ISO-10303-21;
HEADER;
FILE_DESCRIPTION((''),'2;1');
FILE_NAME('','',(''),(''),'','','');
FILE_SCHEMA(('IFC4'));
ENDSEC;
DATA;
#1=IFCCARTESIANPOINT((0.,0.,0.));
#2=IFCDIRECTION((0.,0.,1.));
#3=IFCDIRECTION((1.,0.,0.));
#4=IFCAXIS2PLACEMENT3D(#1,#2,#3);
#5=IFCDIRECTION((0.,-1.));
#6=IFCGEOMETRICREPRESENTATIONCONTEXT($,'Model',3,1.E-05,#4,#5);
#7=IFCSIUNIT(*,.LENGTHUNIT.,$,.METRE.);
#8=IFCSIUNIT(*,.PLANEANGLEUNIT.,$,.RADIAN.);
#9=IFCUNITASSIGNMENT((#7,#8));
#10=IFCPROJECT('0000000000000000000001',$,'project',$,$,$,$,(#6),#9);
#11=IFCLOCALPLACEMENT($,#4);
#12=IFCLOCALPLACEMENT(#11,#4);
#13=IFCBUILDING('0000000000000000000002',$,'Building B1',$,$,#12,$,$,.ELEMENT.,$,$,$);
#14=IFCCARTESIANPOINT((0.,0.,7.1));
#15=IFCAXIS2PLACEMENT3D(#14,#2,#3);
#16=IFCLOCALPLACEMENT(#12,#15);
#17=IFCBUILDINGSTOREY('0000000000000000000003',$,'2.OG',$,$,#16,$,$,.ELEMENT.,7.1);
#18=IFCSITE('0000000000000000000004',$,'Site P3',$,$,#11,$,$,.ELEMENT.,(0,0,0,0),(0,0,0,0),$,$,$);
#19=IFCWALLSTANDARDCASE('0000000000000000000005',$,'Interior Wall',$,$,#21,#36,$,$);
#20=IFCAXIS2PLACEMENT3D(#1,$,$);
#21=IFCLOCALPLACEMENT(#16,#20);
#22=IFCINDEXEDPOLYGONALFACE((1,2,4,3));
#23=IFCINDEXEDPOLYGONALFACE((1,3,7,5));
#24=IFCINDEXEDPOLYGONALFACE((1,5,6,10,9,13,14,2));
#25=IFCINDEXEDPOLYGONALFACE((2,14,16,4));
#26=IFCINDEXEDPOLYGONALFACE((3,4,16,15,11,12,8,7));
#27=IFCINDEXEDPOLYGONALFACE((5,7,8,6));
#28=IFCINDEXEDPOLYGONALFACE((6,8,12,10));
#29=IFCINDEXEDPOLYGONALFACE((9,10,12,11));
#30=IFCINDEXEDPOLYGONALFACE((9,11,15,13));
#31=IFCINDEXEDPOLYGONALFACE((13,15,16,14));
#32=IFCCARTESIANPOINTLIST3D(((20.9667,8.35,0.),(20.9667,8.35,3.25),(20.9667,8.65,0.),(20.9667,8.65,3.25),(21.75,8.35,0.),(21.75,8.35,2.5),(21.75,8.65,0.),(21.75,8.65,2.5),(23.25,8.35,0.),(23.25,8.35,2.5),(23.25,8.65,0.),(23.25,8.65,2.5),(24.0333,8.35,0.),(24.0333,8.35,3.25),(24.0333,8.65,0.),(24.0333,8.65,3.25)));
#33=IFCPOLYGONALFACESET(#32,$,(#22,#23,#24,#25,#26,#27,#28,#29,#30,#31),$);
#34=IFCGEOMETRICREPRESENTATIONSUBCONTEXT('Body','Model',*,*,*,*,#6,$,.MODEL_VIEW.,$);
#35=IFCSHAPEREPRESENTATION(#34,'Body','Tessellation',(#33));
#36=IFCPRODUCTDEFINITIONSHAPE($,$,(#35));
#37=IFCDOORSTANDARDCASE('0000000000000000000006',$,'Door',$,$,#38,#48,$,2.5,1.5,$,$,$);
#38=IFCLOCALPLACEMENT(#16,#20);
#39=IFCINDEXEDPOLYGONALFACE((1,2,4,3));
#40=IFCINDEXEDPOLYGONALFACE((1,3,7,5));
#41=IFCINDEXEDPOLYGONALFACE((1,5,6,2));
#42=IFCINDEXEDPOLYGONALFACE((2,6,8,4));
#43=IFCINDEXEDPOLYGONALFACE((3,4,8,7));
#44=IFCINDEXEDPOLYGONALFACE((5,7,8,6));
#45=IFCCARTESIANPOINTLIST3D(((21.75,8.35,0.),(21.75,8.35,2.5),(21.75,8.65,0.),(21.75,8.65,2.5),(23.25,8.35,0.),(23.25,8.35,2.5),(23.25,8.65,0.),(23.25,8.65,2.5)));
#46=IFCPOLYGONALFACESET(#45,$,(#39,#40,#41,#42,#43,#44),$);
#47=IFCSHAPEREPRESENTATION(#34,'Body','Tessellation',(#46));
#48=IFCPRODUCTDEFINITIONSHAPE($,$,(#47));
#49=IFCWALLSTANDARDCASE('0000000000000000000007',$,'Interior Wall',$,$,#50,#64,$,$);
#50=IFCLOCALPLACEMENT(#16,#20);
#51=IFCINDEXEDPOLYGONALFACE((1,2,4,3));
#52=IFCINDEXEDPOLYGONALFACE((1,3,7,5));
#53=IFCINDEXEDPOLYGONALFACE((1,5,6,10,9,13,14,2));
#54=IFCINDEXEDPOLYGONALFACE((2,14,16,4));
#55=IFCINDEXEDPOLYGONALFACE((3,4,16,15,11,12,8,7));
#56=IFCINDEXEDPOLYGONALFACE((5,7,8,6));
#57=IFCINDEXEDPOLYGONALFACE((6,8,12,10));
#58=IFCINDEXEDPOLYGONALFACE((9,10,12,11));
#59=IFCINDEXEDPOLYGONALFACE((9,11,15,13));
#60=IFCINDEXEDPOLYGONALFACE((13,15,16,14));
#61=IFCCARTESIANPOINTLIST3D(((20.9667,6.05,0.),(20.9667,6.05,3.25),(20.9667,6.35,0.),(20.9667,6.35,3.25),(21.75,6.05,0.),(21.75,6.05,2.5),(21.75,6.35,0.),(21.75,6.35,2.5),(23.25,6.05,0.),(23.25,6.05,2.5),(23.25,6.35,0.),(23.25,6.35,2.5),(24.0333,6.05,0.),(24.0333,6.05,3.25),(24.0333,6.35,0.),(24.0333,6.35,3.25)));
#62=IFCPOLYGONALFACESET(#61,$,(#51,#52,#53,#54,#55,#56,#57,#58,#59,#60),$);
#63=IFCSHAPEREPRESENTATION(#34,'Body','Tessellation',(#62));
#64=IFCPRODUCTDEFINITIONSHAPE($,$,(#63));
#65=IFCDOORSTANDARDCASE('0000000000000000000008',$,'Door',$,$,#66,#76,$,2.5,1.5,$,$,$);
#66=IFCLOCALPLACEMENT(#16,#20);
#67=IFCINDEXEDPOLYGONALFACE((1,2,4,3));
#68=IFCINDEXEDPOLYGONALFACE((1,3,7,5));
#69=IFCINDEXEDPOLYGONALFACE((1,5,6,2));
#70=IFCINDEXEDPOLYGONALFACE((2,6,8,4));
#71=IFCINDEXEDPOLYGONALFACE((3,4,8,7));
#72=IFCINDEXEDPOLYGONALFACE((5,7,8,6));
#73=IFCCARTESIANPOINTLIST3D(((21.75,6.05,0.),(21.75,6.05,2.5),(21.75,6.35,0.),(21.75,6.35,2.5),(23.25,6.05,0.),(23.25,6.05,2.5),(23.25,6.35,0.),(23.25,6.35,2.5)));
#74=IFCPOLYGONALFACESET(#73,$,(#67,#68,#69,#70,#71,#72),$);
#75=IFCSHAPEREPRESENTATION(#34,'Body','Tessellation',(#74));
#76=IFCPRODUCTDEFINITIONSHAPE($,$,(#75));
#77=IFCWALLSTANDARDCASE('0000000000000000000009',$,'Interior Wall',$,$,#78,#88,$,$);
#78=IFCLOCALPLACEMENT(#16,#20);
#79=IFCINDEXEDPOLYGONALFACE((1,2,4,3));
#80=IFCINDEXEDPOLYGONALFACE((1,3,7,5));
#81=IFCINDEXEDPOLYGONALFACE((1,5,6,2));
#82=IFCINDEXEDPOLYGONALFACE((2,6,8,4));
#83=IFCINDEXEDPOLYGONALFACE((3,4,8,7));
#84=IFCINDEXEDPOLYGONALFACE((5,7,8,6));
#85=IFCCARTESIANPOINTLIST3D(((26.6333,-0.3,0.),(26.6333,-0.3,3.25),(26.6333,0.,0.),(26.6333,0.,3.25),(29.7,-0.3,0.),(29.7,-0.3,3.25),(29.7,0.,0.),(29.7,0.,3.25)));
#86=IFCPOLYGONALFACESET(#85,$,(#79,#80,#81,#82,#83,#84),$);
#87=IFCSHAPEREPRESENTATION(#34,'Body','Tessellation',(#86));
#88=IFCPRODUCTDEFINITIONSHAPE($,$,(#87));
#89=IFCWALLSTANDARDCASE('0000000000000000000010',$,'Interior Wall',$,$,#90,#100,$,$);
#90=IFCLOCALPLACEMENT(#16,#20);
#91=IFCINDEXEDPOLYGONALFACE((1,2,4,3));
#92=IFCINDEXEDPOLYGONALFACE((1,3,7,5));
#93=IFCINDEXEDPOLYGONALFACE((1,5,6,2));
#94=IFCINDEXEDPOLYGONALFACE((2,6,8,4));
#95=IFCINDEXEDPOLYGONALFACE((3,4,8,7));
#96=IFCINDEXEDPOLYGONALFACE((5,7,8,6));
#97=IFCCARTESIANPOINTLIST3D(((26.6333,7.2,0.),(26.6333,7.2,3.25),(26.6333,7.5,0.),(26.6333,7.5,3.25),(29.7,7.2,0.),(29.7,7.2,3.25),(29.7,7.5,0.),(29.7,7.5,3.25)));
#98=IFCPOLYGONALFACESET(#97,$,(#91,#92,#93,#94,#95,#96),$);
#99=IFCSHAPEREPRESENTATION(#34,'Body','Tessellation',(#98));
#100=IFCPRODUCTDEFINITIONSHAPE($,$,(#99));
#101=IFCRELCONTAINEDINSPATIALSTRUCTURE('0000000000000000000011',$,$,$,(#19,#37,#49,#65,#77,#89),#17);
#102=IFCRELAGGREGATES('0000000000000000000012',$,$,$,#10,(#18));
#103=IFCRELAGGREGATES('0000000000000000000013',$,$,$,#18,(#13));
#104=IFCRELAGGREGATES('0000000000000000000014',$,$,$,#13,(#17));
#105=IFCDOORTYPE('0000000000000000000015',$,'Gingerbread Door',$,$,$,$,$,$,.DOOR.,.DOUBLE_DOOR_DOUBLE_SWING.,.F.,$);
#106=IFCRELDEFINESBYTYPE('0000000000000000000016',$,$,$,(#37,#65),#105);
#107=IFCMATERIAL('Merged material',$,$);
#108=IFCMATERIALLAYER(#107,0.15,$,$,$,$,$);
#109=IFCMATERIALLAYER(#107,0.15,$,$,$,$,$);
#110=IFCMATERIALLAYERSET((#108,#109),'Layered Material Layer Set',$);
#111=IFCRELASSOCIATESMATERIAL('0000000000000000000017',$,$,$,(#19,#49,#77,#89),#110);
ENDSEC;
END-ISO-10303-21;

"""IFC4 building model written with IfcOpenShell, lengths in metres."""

from ifc_helpers import new_model, si_unit, direction, frame, origin_with_axes, place, context, subcontext, project, spatial, polyline, outline, extrude, source, transform, mapped, material, layer, layer_set, layer_usage, type_object, element, fill, save


model = new_model("IFC4")

# Units and contexts
model_context = context("Model", 3, precision=1e-05, world=origin_with_axes(), true_north=direction((0.0, -1.0)))
body_context = subcontext(model_context, "Body", "Model", "MODEL_VIEW")
ifc_project = project(units=[si_unit("LENGTHUNIT", "METRE"), si_unit("PLANEANGLEUNIT", "RADIAN")], contexts=[model_context])

# Site, building, storey
site_placement = place(None, origin_with_axes())
site = spatial("IfcSite", under=ifc_project, at=site_placement, Name="Site P3", CompositionType="ELEMENT", RefLatitude=(0, 0, 0, 0), RefLongitude=(0, 0, 0, 0))
building_placement = place(site_placement, origin_with_axes())
building = spatial("IfcBuilding", under=site, at=building_placement, Name="Building B1", CompositionType="ELEMENT")
storey_placement = place(building_placement, frame((0.0, 0.0, 7.1), z_axis=(0.0, 0.0, 1.0), x_axis=(1.0, 0.0, 0.0)))
storey = spatial("IfcBuildingStorey", under=building, at=storey_placement, Name="2.OG", CompositionType="ELEMENT", Elevation=7.1)

# Shared definitions
ifc_material = material(Name="Merged material")

# Shared definitions
ifc_layer_1 = layer(ifc_material, 0.15)
ifc_layer_2 = layer(ifc_material, 0.15)
ifc_layer_set_1 = layer_set([ifc_layer_1, ifc_layer_2], Name="Layered Material Layer Set")
ifc_layer_usage_1 = layer_usage(ifc_layer_set_1, "AXIS2", "POSITIVE", -0.15)
door_type = type_object("IfcDoorType", Name="Gingerbread Door", OperationType="DOUBLE_DOOR_DOUBLE_SWING", ParameterTakesPrecedence=False, PredefinedType="DOOR")
shared_shape_1 = source(origin_with_axes(), body_context, "Body", "SweptSolid", [
    extrude(outline(polyline([(0.0, 0.0), (0.0, 1.5), (2.5, 1.5), (2.5, 0.0), (0.0, 0.0)])), frame((0.0, -0.15, 0.0), z_axis=(0.0, 1.0, 0.0), x_axis=(0.0, 0.0, 1.0)), (0.0, 0.0, 1.0), 0.3),
])

# Walls, openings, doors
wall_1_placement = place(storey_placement, frame((20.9667, 8.5, 0.0), z_axis=(0.0, 0.0, 1.0), x_axis=(1.0, 0.0, 0.0)))
wall_1 = element("IfcWallStandardCase", 1, at=wall_1_placement, inside=storey, material=ifc_layer_usage_1, Name="Interior Wall", context=body_context, shape_type="SweptSolid", body=[
    extrude(outline(polyline([(0.0, 0.15), (3.0667, 0.15), (3.0667, -0.15), (0.0, -0.15), (0.0, 0.15)])), origin_with_axes(), (0.0, 0.0, 1.0), 3.25),
])
opening_1_placement = place(wall_1_placement, frame((0.7833, 0.0, 0.0), z_axis=(0.0, 0.0, 1.0), x_axis=(1.0, 0.0, 0.0)))
opening_1 = element("IfcOpeningStandardCase", 2, at=opening_1_placement, cuts=wall_1, context=body_context, shape_type="SweptSolid", body=[
    extrude(outline(polyline([(0.0, 0.0), (0.0, 1.5), (2.5, 1.5), (2.5, 0.0), (0.0, 0.0)])), frame((0.0, -0.15, 0.0), z_axis=(0.0, 1.0, 0.0), x_axis=(0.0, 0.0, 1.0)), (0.0, 0.0, 1.0), 0.3),
])
door_1_placement = place(opening_1_placement, origin_with_axes())
door_1 = element("IfcDoorStandardCase", 3, at=door_1_placement, inside=storey, type_object=door_type, Name="Door", OverallHeight=2.5, OverallWidth=1.5, context=body_context, shape_type="MappedRepresentation", body=[
    mapped(shared_shape_1, transform((0.0, 0.0, 0.0))),
])
fill(opening_1, door_1)
wall_2_placement = place(storey_placement, frame((20.9667, 6.2, 0.0), z_axis=(0.0, 0.0, 1.0), x_axis=(1.0, 0.0, 0.0)))
wall_2 = element("IfcWallStandardCase", 4, at=wall_2_placement, inside=storey, material=ifc_layer_usage_1, Name="Interior Wall", context=body_context, shape_type="SweptSolid", body=[
    extrude(outline(polyline([(0.0, 0.15), (3.0667, 0.15), (3.0667, -0.15), (0.0, -0.15), (0.0, 0.15)])), origin_with_axes(), (0.0, 0.0, 1.0), 3.25),
])
opening_2_placement = place(wall_2_placement, frame((0.7833, 0.0, 0.0), z_axis=(0.0, 0.0, 1.0), x_axis=(1.0, 0.0, 0.0)))
opening_2 = element("IfcOpeningStandardCase", 5, at=opening_2_placement, cuts=wall_2, context=body_context, shape_type="SweptSolid", body=[
    extrude(outline(polyline([(0.0, 0.0), (0.0, 1.5), (2.5, 1.5), (2.5, 0.0), (0.0, 0.0)])), frame((0.0, -0.15, 0.0), z_axis=(0.0, 1.0, 0.0), x_axis=(0.0, 0.0, 1.0)), (0.0, 0.0, 1.0), 0.3),
])
door_2_placement = place(opening_2_placement, origin_with_axes())
door_2 = element("IfcDoorStandardCase", 6, at=door_2_placement, inside=storey, type_object=door_type, Name="Door", OverallHeight=2.5, OverallWidth=1.5, context=body_context, shape_type="MappedRepresentation", body=[
    mapped(shared_shape_1, transform((0.0, 0.0, 0.0))),
])
fill(opening_2, door_2)

# Walls
for number, where, z_axis, x_axis, name in (
    (7, (26.6333, -0.15, 0.0), (0.0, 0.0, 1.0), (1.0, 0.0, 0.0), "Interior Wall"),
    (8, (26.6333, 7.35, 0.0), (0.0, 0.0, 1.0), (1.0, 0.0, 0.0), "Interior Wall"),
):
    element("IfcWallStandardCase", number, at=place(storey_placement, frame(where, z_axis=z_axis, x_axis=x_axis)), inside=storey, material=ifc_layer_usage_1, Name=name, context=body_context, shape_type="SweptSolid", body=[
        extrude(outline(polyline([(0.0, 0.15), (3.0667, 0.15), (3.0667, -0.15), (0.0, -0.15), (0.0, 0.15)])), origin_with_axes(), (0.0, 0.0, 1.0), 3.25),
    ])

save(model, "model.ifc")
